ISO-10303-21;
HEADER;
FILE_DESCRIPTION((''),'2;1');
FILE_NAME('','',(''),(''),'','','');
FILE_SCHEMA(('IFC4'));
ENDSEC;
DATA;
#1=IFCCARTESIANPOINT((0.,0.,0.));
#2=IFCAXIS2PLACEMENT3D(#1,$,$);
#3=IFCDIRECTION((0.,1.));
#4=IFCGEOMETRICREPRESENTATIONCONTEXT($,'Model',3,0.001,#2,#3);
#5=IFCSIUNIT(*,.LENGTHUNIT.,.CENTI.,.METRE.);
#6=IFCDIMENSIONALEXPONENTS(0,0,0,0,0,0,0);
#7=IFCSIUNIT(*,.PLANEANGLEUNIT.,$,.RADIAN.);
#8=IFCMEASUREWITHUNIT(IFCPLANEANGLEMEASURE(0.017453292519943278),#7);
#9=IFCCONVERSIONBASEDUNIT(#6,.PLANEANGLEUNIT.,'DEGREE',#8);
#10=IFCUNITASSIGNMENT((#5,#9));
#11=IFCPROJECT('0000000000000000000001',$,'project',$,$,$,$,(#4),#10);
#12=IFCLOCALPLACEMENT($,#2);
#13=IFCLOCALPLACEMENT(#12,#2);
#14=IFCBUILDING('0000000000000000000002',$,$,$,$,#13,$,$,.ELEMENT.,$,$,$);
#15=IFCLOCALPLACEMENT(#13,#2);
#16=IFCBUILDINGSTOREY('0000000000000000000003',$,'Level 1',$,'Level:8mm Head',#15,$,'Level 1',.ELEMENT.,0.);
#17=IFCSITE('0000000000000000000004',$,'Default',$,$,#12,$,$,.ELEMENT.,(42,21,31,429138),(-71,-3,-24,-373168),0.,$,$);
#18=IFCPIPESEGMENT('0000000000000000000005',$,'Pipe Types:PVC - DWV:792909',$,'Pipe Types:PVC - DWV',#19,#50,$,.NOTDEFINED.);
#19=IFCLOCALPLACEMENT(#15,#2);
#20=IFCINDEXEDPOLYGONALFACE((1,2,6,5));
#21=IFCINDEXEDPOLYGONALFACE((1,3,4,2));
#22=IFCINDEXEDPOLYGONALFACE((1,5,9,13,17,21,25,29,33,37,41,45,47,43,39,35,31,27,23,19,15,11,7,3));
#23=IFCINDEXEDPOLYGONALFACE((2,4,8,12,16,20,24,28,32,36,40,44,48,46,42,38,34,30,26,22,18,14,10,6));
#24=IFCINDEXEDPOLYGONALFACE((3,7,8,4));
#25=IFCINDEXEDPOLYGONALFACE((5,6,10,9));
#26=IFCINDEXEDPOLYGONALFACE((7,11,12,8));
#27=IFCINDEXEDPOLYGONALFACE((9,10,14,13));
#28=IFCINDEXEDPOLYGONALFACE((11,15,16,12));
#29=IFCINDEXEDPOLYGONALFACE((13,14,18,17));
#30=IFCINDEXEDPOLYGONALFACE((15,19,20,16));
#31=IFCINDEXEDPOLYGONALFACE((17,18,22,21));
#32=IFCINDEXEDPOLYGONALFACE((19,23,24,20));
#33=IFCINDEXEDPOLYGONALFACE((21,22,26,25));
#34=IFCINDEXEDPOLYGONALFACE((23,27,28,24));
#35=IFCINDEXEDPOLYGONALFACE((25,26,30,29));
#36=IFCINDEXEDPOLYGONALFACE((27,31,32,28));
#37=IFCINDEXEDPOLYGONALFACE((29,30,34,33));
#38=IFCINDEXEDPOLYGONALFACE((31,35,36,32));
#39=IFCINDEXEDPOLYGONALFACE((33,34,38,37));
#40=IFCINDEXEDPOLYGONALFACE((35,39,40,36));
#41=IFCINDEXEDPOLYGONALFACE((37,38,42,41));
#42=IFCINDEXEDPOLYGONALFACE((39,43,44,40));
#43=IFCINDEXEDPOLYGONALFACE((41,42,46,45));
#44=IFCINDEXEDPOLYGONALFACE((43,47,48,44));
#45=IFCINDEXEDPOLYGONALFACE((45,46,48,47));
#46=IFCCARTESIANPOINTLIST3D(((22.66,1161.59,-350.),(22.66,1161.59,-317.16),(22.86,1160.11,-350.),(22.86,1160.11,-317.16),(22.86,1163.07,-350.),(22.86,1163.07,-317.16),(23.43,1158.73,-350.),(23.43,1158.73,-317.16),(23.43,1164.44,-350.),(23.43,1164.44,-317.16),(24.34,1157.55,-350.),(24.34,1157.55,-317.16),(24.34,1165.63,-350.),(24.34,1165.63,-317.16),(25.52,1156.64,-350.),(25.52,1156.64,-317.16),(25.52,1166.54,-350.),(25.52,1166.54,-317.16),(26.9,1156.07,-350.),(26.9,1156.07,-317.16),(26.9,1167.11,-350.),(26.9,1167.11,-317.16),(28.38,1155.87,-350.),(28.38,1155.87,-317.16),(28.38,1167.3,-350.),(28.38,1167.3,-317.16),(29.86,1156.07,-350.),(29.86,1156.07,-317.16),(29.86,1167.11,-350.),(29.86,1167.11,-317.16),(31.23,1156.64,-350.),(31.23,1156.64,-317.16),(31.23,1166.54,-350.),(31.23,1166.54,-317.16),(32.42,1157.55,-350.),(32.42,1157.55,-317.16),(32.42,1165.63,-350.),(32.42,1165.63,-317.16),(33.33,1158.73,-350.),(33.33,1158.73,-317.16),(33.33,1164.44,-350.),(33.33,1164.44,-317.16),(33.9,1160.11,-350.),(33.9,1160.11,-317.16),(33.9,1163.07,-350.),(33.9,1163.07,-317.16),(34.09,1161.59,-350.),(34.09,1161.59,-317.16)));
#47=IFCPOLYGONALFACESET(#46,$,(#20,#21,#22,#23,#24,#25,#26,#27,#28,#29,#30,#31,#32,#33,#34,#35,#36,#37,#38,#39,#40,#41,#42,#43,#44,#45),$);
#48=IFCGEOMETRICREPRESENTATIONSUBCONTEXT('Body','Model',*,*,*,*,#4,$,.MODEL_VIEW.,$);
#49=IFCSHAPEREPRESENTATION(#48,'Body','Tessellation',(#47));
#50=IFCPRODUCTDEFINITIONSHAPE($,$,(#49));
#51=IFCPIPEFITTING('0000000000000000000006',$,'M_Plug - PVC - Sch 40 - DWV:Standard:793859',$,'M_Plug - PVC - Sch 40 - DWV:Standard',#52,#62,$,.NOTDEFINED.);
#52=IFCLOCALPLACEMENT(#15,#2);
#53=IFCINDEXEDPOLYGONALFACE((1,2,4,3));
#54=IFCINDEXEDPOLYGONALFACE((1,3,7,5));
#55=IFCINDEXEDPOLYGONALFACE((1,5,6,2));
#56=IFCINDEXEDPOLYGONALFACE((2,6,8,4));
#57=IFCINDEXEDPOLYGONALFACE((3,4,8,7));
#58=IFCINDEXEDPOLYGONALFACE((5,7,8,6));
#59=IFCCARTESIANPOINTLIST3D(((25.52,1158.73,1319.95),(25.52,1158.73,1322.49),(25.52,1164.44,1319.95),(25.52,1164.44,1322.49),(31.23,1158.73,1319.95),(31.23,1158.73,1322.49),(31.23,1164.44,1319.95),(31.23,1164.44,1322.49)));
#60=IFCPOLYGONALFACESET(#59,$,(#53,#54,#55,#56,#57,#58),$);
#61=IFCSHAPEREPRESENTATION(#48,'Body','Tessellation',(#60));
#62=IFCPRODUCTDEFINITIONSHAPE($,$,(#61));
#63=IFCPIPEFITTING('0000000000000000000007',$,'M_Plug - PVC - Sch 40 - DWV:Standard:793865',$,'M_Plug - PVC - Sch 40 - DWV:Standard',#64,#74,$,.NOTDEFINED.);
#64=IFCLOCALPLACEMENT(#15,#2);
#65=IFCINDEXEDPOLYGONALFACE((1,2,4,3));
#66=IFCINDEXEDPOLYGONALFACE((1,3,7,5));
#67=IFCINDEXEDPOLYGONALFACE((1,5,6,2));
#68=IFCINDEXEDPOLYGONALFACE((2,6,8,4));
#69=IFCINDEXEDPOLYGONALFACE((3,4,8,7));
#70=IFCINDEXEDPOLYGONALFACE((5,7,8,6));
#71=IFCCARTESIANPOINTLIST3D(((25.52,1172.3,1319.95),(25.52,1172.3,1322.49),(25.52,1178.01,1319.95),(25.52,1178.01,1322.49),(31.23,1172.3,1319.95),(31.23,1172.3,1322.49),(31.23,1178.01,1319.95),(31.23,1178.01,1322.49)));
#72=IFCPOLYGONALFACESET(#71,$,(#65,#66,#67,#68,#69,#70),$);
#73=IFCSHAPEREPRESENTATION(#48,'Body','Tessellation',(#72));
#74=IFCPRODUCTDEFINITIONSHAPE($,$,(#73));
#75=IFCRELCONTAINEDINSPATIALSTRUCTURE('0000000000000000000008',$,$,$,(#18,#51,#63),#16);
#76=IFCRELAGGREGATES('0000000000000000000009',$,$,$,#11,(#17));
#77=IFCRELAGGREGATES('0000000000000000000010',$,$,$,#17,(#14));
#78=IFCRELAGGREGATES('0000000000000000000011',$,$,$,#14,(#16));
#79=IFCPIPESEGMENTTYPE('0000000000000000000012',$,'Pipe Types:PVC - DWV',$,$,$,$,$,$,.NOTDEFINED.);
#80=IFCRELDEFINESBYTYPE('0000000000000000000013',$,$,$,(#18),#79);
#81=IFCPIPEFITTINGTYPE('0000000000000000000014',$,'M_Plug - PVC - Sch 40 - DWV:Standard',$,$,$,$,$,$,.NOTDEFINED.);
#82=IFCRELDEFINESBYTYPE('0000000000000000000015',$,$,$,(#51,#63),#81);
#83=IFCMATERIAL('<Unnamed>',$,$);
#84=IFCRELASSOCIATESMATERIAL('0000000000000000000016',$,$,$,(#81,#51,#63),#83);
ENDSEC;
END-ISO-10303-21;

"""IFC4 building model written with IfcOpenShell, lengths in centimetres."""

from ifc_helpers import new_model, entity, si_unit, converted_unit, direction, frame, origin, place, context, subcontext, project, spatial, arc, indexed_curve, outline, extrude, source, transform, mapped, material, type_object, type_shapes, element, save


model = new_model("IFC4")

# Units and contexts
model_context = context("Model", 3, precision=0.001, world=origin(), true_north=direction((0.0, 1.0)))
body_context = subcontext(model_context, "Body", "Model", "MODEL_VIEW")
ifc_project = project(units=[si_unit("LENGTHUNIT", "METRE", prefix="CENTI"), converted_unit("PLANEANGLEUNIT", "DEGREE", entity("IfcPlaneAngleMeasure", 0.017453292519943278), si_unit("PLANEANGLEUNIT", "RADIAN"), dimensions=[0, 0, 0, 0, 0, 0, 0])], contexts=[model_context])

# Site, building, storey
site_placement = place(None, origin())
site = spatial("IfcSite", under=ifc_project, at=site_placement, Name="Default", CompositionType="ELEMENT", RefLatitude=(42, 21, 31, 429138), RefLongitude=(-71, -3, -24, -373168), RefElevation=0.0)
building_placement = place(site_placement, origin())
building = spatial("IfcBuilding", under=site, at=building_placement, CompositionType="ELEMENT")
storey_placement = place(building_placement, origin())
storey = spatial("IfcBuildingStorey", under=building, at=storey_placement, Name="Level 1", ObjectType="Level:8mm Head", LongName="Level 1", CompositionType="ELEMENT", Elevation=0.0)

# Pipe segment
pipe_segment_type = type_object("IfcPipeSegmentType", Name="Pipe Types:PVC - DWV", PredefinedType="NOTDEFINED")
pipe_segment_1_placement = place(storey_placement, origin())
element("IfcPipeSegment", 1, at=pipe_segment_1_placement, inside=storey, type_object=pipe_segment_type, Name="Pipe Types:PVC - DWV:792909", ObjectType="Pipe Types:PVC - DWV", PredefinedType="NOTDEFINED", context=body_context, shape_type="SweptSolid", body=[
    extrude(outline(indexed_curve([(5.72, 0.0), (4.04, 4.04), (0.0, 5.71), (-4.04, 4.04), (-5.71, 0.0), (-4.04, -4.04), (0.0, -5.71), (4.04, -4.04)], segments=[arc(1, 2, 3), arc(3, 4, 5), arc(5, 6, 7), arc(7, 8, 1)], self_intersect=False)), frame((28.38, 1161.59, -350.0), z_axis=(0.0, 0.0, 1.0), x_axis=(-1.0, 0.0, 0.0)), (0.0, 0.0, 1.0), 32.84),
])

# Pipe fittings
ifc_material = material(Name="<Unnamed>")
pipe_fitting_type = type_object("IfcPipeFittingType", Name="M_Plug - PVC - Sch 40 - DWV:Standard", PredefinedType="NOTDEFINED", material=ifc_material)
shared_shape = source(origin(), body_context, "Body", "SweptSolid", [
    extrude(outline(indexed_curve([(-1.27, -2.86), (1.27, -2.86), (1.27, 2.86), (-1.27, 2.86), (-1.27, -2.86)], self_intersect=False)), frame((1.27, 0.0, -2.86), z_axis=(0.0, 0.0, 1.0), x_axis=(-1.0, 0.0, 0.0)), (0.0, 0.0, 1.0), 5.71),
])
type_shapes(pipe_fitting_type, [shared_shape])
for number, where, z_axis, x_axis, name in (
    (2, (28.38, 1161.59, 1319.95), (1.0, 0.0, 0.0), (0.0, 0.0, 1.0), "M_Plug - PVC - Sch 40 - DWV:Standard:793859"),
    (3, (28.38, 1175.15, 1319.95), (1.0, 0.0, 0.0), (0.0, 0.0, 1.0), "M_Plug - PVC - Sch 40 - DWV:Standard:793865"),
):
    element("IfcPipeFitting", number, at=place(storey_placement, frame(where, z_axis=z_axis, x_axis=x_axis)), inside=storey, type_object=pipe_fitting_type, material=ifc_material, Name=name, ObjectType="M_Plug - PVC - Sch 40 - DWV:Standard", PredefinedType="NOTDEFINED", context=body_context, shape_type="MappedRepresentation", body=[
        mapped(shared_shape, transform((0.0, 0.0, 0.0), scale=1.0)),
    ])

save(model, "model.ifc")
